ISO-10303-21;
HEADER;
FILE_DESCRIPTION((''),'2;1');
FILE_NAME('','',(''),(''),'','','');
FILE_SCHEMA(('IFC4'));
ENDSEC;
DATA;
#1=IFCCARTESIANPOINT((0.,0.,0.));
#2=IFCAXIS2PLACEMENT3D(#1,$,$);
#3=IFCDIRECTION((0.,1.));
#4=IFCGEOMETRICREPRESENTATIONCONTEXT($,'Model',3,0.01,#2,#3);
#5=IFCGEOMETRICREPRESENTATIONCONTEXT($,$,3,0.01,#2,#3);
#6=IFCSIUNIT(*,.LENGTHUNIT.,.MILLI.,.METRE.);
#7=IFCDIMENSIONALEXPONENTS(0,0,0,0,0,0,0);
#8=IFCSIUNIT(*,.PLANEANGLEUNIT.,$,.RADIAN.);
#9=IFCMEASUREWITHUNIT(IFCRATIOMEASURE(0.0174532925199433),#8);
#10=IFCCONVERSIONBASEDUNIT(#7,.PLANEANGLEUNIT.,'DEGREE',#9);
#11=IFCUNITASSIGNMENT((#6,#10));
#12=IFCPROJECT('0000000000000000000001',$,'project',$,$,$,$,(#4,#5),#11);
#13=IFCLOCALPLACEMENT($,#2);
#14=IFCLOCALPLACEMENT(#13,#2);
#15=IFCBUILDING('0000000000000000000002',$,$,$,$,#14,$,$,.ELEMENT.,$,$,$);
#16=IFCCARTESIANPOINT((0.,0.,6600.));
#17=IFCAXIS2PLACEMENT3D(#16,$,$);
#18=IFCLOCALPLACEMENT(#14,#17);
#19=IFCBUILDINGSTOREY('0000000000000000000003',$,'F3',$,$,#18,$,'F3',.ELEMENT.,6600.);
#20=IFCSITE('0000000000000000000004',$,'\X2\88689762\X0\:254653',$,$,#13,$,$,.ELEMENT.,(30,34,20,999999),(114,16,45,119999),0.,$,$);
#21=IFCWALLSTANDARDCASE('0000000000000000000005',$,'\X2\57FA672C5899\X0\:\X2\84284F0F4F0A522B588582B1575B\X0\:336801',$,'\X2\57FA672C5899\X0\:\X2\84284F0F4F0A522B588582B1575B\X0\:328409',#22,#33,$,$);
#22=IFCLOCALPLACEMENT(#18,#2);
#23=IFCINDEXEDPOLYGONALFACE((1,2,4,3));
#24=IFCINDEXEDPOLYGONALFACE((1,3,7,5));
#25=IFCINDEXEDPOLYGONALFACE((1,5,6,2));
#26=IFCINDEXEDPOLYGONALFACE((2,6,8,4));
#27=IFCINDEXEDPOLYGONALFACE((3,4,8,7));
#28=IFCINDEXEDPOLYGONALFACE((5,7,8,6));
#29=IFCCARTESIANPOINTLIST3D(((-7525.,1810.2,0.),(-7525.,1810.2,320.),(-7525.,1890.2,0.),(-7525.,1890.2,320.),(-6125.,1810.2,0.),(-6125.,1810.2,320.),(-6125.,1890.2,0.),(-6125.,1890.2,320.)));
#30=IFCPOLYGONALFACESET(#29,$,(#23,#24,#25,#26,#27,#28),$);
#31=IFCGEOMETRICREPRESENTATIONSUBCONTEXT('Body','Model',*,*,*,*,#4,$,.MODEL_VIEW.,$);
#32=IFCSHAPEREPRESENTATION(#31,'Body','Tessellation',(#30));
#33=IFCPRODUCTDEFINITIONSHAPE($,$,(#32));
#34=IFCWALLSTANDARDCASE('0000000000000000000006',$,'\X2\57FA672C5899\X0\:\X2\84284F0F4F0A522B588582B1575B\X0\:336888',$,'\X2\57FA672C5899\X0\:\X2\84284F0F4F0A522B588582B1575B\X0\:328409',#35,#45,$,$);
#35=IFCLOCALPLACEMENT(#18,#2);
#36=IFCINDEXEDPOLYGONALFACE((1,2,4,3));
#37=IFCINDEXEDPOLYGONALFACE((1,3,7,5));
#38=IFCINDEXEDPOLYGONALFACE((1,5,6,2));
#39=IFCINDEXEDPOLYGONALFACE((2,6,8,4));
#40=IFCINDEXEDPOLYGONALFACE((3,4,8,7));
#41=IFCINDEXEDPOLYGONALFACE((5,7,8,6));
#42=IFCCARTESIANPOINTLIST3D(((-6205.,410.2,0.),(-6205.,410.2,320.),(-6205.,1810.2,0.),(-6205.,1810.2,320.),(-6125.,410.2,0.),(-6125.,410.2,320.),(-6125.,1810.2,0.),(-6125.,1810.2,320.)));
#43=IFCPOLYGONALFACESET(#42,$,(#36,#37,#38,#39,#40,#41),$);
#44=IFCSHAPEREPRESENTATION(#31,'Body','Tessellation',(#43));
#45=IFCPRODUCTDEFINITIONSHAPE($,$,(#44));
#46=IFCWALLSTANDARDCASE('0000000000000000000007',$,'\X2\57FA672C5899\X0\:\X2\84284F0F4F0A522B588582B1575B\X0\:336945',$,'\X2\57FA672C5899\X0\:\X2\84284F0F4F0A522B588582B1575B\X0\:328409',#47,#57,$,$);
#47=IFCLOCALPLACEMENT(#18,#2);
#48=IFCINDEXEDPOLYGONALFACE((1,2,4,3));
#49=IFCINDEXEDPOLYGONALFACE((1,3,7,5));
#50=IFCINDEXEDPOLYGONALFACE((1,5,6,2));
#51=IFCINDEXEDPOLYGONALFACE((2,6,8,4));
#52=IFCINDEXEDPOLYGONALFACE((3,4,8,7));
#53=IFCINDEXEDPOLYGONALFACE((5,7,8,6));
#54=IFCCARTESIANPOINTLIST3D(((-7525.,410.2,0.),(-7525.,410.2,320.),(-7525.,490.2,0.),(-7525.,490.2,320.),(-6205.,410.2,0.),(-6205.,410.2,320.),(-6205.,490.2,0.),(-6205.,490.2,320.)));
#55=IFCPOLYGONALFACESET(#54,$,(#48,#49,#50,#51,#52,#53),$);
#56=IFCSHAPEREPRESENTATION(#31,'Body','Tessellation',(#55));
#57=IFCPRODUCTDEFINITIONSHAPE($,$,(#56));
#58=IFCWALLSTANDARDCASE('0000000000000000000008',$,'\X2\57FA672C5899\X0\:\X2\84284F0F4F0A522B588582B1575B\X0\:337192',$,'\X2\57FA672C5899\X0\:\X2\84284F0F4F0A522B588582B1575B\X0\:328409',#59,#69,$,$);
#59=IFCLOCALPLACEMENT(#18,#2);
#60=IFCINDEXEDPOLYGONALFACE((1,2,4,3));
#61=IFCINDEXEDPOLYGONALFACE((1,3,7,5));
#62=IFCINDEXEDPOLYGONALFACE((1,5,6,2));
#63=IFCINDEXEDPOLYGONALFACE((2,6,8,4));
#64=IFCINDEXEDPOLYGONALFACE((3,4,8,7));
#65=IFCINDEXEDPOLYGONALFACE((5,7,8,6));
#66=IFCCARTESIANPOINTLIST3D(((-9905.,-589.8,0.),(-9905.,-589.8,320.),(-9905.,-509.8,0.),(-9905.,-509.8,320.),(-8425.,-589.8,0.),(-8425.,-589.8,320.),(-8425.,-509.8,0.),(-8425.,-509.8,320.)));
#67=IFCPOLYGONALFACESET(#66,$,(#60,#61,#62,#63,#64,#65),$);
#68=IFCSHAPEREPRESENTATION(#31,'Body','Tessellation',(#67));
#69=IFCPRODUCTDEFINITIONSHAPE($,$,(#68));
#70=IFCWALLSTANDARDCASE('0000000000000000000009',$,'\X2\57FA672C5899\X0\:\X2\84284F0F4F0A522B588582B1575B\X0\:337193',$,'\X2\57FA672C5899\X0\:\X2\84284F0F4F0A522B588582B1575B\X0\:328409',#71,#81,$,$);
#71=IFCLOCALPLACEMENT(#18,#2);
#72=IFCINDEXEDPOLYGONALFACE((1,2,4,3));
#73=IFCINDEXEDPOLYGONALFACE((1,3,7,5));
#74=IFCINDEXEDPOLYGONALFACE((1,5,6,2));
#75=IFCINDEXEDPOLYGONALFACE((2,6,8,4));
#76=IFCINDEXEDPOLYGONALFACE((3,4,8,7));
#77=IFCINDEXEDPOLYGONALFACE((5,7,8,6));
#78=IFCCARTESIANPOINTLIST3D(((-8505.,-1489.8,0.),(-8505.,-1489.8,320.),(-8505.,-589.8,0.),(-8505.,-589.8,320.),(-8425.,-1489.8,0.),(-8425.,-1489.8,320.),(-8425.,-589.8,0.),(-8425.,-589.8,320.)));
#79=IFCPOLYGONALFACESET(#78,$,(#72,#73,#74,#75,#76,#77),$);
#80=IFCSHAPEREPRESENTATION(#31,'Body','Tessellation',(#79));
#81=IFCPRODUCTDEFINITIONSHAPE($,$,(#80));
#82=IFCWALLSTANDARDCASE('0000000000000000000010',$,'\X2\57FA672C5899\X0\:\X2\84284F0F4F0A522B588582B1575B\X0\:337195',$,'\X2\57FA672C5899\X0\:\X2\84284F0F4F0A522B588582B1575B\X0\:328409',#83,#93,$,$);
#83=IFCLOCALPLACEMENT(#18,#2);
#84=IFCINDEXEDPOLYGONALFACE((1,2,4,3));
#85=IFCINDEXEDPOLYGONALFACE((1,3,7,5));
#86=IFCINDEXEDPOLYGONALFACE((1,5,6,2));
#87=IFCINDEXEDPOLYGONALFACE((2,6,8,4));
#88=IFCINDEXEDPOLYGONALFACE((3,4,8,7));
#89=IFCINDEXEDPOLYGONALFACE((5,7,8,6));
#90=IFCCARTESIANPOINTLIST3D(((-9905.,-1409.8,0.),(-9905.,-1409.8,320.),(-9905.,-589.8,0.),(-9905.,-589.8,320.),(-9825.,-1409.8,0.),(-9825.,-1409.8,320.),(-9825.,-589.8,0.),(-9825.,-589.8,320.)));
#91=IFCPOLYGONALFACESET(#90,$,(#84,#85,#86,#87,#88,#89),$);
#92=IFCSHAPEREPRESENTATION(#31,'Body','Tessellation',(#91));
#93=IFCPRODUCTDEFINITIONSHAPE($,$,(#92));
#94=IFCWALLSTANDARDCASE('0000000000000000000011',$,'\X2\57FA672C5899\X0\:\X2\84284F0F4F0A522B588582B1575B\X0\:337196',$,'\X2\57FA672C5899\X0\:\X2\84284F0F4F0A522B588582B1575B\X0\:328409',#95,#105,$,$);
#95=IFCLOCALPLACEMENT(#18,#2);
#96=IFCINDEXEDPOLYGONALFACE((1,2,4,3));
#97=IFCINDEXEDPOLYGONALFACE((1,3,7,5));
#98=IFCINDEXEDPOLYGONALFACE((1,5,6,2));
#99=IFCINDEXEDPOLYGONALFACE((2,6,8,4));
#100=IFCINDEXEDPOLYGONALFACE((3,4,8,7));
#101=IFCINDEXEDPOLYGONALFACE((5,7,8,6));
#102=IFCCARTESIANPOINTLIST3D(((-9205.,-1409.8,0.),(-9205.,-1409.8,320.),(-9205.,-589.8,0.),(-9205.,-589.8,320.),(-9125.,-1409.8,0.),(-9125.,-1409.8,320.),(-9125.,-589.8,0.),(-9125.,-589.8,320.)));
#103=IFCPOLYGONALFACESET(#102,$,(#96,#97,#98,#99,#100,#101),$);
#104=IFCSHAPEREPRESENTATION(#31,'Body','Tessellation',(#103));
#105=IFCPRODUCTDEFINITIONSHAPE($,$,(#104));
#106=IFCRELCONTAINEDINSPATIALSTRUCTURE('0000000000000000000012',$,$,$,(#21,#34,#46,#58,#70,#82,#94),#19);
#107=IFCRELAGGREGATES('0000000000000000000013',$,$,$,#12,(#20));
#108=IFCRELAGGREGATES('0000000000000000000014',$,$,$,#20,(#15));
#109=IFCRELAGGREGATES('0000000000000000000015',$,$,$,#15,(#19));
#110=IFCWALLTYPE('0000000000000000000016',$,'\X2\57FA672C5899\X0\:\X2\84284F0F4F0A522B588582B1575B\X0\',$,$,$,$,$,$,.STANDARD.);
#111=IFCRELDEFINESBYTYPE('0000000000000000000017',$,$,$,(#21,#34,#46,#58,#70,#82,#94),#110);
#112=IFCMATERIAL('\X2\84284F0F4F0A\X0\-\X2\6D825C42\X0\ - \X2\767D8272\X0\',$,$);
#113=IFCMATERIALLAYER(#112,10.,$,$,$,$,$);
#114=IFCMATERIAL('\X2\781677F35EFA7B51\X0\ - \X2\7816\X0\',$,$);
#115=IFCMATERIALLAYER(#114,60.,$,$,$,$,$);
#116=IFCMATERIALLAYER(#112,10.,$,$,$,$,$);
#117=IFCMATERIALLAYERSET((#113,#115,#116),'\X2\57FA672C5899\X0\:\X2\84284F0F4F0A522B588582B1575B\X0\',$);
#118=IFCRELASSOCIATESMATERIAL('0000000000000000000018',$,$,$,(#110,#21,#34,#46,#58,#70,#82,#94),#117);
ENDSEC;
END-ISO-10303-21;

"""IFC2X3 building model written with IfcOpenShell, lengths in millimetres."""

from ifc_helpers import new_model, entity, si_unit, converted_unit, direction, frame, frame_2d, origin, place, context, subcontext, project, spatial, rectangle, extrude, material, layer, layer_set, layer_usage, type_object, element, save


model = new_model("IFC2X3")

# Units and contexts
model_context = context("Model", 3, precision=0.01, world=origin(), true_north=direction((0.0, 1.0)))
context_of_model = context(None, 3, precision=0.01, world=origin(), true_north=direction((0.0, 1.0)))
body_context = subcontext(model_context, "Body", "Model", "MODEL_VIEW")
ifc_project = project(units=[si_unit("LENGTHUNIT", "METRE", prefix="MILLI"), converted_unit("PLANEANGLEUNIT", "DEGREE", entity("IfcRatioMeasure", 0.0174532925199433), si_unit("PLANEANGLEUNIT", "RADIAN"), dimensions=[0, 0, 0, 0, 0, 0, 0])], contexts=[model_context, context_of_model])

# Site, building, storey
site_placement = place(None, origin())
site = spatial("IfcSite", under=ifc_project, at=site_placement, Name="表面:254653", CompositionType="ELEMENT", RefLatitude=(30, 34, 20, 999999), RefLongitude=(114, 16, 45, 119999), RefElevation=0.0)
building_placement = place(site_placement, origin())
building = spatial("IfcBuilding", under=site, at=building_placement, CompositionType="ELEMENT")
storey_placement = place(building_placement, frame((0.0, 0.0, 6600.0)))
storey = spatial("IfcBuildingStorey", under=building, at=storey_placement, Name="F3", LongName="F3", CompositionType="ELEMENT", Elevation=6600.0)

# Walls
ifc_material_1 = material(Name="萨伏伊-涂层 - 白色")
ifc_layer_1 = layer(ifc_material_1, 10.0)
ifc_material_2 = material(Name="砖石建筑 - 砖")
ifc_layer_2 = layer(ifc_material_2, 60.0)
ifc_layer_3 = layer(ifc_material_1, 10.0)
ifc_layer_set = layer_set([ifc_layer_1, ifc_layer_2, ifc_layer_3], Name="基本墙:萨伏伊别墅花坛")
wall_type = type_object("IfcWallType", Name="基本墙:萨伏伊别墅花坛", PredefinedType="STANDARD", material=ifc_layer_set)
ifc_layer_usage_1 = layer_usage(ifc_layer_set, "AXIS2", "NEGATIVE", 40.0)
wall_1_placement = place(storey_placement, frame((-7525.0, 1850.2, 0.0)))
element("IfcWallStandardCase", 1, at=wall_1_placement, inside=storey, type_object=wall_type, material=ifc_layer_usage_1, Name="基本墙:萨伏伊别墅花坛:336801", ObjectType="基本墙:萨伏伊别墅花坛:328409", context=body_context, shape_type="SweptSolid", body=[
    extrude(rectangle(XDim=1400.0, YDim=80.0, at=frame_2d((700.0, 0.0), x_axis=(-1.0, 0.0))), origin(), (0.0, 0.0, 1.0), 320.0),
])
ifc_layer_usage_2 = layer_usage(ifc_layer_set, "AXIS2", "NEGATIVE", 40.0)
wall_2_placement = place(storey_placement, frame((-6165.0, 1810.2, 0.0), z_axis=(0.0, 0.0, 1.0), x_axis=(0.0, -1.0, 0.0)))
element("IfcWallStandardCase", 2, at=wall_2_placement, inside=storey, type_object=wall_type, material=ifc_layer_usage_2, Name="基本墙:萨伏伊别墅花坛:336888", ObjectType="基本墙:萨伏伊别墅花坛:328409", context=body_context, shape_type="SweptSolid", body=[
    extrude(rectangle(XDim=1400.0, YDim=80.0, at=frame_2d((700.0, 0.0), x_axis=(-1.0, 0.0))), origin(), (0.0, 0.0, 1.0), 320.0),
])
ifc_layer_usage_3 = layer_usage(ifc_layer_set, "AXIS2", "NEGATIVE", 40.0)
wall_3_placement = place(storey_placement, frame((-6205.0, 450.2, 0.0), z_axis=(0.0, 0.0, 1.0), x_axis=(-1.0, 0.0, 0.0)))
element("IfcWallStandardCase", 3, at=wall_3_placement, inside=storey, type_object=wall_type, material=ifc_layer_usage_3, Name="基本墙:萨伏伊别墅花坛:336945", ObjectType="基本墙:萨伏伊别墅花坛:328409", context=body_context, shape_type="SweptSolid", body=[
    extrude(rectangle(XDim=1320.0, YDim=80.0, at=frame_2d((660.0, 0.0), x_axis=(-1.0, 0.0))), origin(), (0.0, 0.0, 1.0), 320.0),
])
ifc_layer_usage_4 = layer_usage(ifc_layer_set, "AXIS2", "NEGATIVE", 40.0)
wall_4_placement = place(storey_placement, frame((-9905.0, -549.8, 0.0)))
element("IfcWallStandardCase", 4, at=wall_4_placement, inside=storey, type_object=wall_type, material=ifc_layer_usage_4, Name="基本墙:萨伏伊别墅花坛:337192", ObjectType="基本墙:萨伏伊别墅花坛:328409", context=body_context, shape_type="SweptSolid", body=[
    extrude(rectangle(XDim=1480.0, YDim=80.0, at=frame_2d((740.0, 0.0), x_axis=(-1.0, 0.0))), origin(), (0.0, 0.0, 1.0), 320.0),
])
ifc_layer_usage_5 = layer_usage(ifc_layer_set, "AXIS2", "NEGATIVE", 40.0)
wall_5_placement = place(storey_placement, frame((-8465.0, -589.8, 0.0), z_axis=(0.0, 0.0, 1.0), x_axis=(0.0, -1.0, 0.0)))
element("IfcWallStandardCase", 5, at=wall_5_placement, inside=storey, type_object=wall_type, material=ifc_layer_usage_5, Name="基本墙:萨伏伊别墅花坛:337193", ObjectType="基本墙:萨伏伊别墅花坛:328409", context=body_context, shape_type="SweptSolid", body=[
    extrude(rectangle(XDim=900.0, YDim=80.0, at=frame_2d((450.0, 0.0), x_axis=(-1.0, 0.0))), origin(), (0.0, 0.0, 1.0), 320.0),
])
ifc_layer_usage_6 = layer_usage(ifc_layer_set, "AXIS2", "NEGATIVE", 40.0)
wall_6_placement = place(storey_placement, frame((-9865.0, -1409.8, 0.0), z_axis=(0.0, 0.0, 1.0), x_axis=(0.0, 1.0, 0.0)))
element("IfcWallStandardCase", 6, at=wall_6_placement, inside=storey, type_object=wall_type, material=ifc_layer_usage_6, Name="基本墙:萨伏伊别墅花坛:337195", ObjectType="基本墙:萨伏伊别墅花坛:328409", context=body_context, shape_type="SweptSolid", body=[
    extrude(rectangle(XDim=820.0, YDim=80.0, at=frame_2d((410.0, 0.0), x_axis=(-1.0, 0.0))), origin(), (0.0, 0.0, 1.0), 320.0),
])
ifc_layer_usage_7 = layer_usage(ifc_layer_set, "AXIS2", "NEGATIVE", 40.0)
wall_7_placement = place(storey_placement, frame((-9165.0, -589.8, 0.0), z_axis=(0.0, 0.0, 1.0), x_axis=(0.0, -1.0, 0.0)))
element("IfcWallStandardCase", 7, at=wall_7_placement, inside=storey, type_object=wall_type, material=ifc_layer_usage_7, Name="基本墙:萨伏伊别墅花坛:337196", ObjectType="基本墙:萨伏伊别墅花坛:328409", context=body_context, shape_type="SweptSolid", body=[
    extrude(rectangle(XDim=820.0, YDim=80.0, at=frame_2d((410.0, 0.0), x_axis=(-1.0, 0.0))), origin(), (0.0, 0.0, 1.0), 320.0),
])

save(model, "model.ifc")
